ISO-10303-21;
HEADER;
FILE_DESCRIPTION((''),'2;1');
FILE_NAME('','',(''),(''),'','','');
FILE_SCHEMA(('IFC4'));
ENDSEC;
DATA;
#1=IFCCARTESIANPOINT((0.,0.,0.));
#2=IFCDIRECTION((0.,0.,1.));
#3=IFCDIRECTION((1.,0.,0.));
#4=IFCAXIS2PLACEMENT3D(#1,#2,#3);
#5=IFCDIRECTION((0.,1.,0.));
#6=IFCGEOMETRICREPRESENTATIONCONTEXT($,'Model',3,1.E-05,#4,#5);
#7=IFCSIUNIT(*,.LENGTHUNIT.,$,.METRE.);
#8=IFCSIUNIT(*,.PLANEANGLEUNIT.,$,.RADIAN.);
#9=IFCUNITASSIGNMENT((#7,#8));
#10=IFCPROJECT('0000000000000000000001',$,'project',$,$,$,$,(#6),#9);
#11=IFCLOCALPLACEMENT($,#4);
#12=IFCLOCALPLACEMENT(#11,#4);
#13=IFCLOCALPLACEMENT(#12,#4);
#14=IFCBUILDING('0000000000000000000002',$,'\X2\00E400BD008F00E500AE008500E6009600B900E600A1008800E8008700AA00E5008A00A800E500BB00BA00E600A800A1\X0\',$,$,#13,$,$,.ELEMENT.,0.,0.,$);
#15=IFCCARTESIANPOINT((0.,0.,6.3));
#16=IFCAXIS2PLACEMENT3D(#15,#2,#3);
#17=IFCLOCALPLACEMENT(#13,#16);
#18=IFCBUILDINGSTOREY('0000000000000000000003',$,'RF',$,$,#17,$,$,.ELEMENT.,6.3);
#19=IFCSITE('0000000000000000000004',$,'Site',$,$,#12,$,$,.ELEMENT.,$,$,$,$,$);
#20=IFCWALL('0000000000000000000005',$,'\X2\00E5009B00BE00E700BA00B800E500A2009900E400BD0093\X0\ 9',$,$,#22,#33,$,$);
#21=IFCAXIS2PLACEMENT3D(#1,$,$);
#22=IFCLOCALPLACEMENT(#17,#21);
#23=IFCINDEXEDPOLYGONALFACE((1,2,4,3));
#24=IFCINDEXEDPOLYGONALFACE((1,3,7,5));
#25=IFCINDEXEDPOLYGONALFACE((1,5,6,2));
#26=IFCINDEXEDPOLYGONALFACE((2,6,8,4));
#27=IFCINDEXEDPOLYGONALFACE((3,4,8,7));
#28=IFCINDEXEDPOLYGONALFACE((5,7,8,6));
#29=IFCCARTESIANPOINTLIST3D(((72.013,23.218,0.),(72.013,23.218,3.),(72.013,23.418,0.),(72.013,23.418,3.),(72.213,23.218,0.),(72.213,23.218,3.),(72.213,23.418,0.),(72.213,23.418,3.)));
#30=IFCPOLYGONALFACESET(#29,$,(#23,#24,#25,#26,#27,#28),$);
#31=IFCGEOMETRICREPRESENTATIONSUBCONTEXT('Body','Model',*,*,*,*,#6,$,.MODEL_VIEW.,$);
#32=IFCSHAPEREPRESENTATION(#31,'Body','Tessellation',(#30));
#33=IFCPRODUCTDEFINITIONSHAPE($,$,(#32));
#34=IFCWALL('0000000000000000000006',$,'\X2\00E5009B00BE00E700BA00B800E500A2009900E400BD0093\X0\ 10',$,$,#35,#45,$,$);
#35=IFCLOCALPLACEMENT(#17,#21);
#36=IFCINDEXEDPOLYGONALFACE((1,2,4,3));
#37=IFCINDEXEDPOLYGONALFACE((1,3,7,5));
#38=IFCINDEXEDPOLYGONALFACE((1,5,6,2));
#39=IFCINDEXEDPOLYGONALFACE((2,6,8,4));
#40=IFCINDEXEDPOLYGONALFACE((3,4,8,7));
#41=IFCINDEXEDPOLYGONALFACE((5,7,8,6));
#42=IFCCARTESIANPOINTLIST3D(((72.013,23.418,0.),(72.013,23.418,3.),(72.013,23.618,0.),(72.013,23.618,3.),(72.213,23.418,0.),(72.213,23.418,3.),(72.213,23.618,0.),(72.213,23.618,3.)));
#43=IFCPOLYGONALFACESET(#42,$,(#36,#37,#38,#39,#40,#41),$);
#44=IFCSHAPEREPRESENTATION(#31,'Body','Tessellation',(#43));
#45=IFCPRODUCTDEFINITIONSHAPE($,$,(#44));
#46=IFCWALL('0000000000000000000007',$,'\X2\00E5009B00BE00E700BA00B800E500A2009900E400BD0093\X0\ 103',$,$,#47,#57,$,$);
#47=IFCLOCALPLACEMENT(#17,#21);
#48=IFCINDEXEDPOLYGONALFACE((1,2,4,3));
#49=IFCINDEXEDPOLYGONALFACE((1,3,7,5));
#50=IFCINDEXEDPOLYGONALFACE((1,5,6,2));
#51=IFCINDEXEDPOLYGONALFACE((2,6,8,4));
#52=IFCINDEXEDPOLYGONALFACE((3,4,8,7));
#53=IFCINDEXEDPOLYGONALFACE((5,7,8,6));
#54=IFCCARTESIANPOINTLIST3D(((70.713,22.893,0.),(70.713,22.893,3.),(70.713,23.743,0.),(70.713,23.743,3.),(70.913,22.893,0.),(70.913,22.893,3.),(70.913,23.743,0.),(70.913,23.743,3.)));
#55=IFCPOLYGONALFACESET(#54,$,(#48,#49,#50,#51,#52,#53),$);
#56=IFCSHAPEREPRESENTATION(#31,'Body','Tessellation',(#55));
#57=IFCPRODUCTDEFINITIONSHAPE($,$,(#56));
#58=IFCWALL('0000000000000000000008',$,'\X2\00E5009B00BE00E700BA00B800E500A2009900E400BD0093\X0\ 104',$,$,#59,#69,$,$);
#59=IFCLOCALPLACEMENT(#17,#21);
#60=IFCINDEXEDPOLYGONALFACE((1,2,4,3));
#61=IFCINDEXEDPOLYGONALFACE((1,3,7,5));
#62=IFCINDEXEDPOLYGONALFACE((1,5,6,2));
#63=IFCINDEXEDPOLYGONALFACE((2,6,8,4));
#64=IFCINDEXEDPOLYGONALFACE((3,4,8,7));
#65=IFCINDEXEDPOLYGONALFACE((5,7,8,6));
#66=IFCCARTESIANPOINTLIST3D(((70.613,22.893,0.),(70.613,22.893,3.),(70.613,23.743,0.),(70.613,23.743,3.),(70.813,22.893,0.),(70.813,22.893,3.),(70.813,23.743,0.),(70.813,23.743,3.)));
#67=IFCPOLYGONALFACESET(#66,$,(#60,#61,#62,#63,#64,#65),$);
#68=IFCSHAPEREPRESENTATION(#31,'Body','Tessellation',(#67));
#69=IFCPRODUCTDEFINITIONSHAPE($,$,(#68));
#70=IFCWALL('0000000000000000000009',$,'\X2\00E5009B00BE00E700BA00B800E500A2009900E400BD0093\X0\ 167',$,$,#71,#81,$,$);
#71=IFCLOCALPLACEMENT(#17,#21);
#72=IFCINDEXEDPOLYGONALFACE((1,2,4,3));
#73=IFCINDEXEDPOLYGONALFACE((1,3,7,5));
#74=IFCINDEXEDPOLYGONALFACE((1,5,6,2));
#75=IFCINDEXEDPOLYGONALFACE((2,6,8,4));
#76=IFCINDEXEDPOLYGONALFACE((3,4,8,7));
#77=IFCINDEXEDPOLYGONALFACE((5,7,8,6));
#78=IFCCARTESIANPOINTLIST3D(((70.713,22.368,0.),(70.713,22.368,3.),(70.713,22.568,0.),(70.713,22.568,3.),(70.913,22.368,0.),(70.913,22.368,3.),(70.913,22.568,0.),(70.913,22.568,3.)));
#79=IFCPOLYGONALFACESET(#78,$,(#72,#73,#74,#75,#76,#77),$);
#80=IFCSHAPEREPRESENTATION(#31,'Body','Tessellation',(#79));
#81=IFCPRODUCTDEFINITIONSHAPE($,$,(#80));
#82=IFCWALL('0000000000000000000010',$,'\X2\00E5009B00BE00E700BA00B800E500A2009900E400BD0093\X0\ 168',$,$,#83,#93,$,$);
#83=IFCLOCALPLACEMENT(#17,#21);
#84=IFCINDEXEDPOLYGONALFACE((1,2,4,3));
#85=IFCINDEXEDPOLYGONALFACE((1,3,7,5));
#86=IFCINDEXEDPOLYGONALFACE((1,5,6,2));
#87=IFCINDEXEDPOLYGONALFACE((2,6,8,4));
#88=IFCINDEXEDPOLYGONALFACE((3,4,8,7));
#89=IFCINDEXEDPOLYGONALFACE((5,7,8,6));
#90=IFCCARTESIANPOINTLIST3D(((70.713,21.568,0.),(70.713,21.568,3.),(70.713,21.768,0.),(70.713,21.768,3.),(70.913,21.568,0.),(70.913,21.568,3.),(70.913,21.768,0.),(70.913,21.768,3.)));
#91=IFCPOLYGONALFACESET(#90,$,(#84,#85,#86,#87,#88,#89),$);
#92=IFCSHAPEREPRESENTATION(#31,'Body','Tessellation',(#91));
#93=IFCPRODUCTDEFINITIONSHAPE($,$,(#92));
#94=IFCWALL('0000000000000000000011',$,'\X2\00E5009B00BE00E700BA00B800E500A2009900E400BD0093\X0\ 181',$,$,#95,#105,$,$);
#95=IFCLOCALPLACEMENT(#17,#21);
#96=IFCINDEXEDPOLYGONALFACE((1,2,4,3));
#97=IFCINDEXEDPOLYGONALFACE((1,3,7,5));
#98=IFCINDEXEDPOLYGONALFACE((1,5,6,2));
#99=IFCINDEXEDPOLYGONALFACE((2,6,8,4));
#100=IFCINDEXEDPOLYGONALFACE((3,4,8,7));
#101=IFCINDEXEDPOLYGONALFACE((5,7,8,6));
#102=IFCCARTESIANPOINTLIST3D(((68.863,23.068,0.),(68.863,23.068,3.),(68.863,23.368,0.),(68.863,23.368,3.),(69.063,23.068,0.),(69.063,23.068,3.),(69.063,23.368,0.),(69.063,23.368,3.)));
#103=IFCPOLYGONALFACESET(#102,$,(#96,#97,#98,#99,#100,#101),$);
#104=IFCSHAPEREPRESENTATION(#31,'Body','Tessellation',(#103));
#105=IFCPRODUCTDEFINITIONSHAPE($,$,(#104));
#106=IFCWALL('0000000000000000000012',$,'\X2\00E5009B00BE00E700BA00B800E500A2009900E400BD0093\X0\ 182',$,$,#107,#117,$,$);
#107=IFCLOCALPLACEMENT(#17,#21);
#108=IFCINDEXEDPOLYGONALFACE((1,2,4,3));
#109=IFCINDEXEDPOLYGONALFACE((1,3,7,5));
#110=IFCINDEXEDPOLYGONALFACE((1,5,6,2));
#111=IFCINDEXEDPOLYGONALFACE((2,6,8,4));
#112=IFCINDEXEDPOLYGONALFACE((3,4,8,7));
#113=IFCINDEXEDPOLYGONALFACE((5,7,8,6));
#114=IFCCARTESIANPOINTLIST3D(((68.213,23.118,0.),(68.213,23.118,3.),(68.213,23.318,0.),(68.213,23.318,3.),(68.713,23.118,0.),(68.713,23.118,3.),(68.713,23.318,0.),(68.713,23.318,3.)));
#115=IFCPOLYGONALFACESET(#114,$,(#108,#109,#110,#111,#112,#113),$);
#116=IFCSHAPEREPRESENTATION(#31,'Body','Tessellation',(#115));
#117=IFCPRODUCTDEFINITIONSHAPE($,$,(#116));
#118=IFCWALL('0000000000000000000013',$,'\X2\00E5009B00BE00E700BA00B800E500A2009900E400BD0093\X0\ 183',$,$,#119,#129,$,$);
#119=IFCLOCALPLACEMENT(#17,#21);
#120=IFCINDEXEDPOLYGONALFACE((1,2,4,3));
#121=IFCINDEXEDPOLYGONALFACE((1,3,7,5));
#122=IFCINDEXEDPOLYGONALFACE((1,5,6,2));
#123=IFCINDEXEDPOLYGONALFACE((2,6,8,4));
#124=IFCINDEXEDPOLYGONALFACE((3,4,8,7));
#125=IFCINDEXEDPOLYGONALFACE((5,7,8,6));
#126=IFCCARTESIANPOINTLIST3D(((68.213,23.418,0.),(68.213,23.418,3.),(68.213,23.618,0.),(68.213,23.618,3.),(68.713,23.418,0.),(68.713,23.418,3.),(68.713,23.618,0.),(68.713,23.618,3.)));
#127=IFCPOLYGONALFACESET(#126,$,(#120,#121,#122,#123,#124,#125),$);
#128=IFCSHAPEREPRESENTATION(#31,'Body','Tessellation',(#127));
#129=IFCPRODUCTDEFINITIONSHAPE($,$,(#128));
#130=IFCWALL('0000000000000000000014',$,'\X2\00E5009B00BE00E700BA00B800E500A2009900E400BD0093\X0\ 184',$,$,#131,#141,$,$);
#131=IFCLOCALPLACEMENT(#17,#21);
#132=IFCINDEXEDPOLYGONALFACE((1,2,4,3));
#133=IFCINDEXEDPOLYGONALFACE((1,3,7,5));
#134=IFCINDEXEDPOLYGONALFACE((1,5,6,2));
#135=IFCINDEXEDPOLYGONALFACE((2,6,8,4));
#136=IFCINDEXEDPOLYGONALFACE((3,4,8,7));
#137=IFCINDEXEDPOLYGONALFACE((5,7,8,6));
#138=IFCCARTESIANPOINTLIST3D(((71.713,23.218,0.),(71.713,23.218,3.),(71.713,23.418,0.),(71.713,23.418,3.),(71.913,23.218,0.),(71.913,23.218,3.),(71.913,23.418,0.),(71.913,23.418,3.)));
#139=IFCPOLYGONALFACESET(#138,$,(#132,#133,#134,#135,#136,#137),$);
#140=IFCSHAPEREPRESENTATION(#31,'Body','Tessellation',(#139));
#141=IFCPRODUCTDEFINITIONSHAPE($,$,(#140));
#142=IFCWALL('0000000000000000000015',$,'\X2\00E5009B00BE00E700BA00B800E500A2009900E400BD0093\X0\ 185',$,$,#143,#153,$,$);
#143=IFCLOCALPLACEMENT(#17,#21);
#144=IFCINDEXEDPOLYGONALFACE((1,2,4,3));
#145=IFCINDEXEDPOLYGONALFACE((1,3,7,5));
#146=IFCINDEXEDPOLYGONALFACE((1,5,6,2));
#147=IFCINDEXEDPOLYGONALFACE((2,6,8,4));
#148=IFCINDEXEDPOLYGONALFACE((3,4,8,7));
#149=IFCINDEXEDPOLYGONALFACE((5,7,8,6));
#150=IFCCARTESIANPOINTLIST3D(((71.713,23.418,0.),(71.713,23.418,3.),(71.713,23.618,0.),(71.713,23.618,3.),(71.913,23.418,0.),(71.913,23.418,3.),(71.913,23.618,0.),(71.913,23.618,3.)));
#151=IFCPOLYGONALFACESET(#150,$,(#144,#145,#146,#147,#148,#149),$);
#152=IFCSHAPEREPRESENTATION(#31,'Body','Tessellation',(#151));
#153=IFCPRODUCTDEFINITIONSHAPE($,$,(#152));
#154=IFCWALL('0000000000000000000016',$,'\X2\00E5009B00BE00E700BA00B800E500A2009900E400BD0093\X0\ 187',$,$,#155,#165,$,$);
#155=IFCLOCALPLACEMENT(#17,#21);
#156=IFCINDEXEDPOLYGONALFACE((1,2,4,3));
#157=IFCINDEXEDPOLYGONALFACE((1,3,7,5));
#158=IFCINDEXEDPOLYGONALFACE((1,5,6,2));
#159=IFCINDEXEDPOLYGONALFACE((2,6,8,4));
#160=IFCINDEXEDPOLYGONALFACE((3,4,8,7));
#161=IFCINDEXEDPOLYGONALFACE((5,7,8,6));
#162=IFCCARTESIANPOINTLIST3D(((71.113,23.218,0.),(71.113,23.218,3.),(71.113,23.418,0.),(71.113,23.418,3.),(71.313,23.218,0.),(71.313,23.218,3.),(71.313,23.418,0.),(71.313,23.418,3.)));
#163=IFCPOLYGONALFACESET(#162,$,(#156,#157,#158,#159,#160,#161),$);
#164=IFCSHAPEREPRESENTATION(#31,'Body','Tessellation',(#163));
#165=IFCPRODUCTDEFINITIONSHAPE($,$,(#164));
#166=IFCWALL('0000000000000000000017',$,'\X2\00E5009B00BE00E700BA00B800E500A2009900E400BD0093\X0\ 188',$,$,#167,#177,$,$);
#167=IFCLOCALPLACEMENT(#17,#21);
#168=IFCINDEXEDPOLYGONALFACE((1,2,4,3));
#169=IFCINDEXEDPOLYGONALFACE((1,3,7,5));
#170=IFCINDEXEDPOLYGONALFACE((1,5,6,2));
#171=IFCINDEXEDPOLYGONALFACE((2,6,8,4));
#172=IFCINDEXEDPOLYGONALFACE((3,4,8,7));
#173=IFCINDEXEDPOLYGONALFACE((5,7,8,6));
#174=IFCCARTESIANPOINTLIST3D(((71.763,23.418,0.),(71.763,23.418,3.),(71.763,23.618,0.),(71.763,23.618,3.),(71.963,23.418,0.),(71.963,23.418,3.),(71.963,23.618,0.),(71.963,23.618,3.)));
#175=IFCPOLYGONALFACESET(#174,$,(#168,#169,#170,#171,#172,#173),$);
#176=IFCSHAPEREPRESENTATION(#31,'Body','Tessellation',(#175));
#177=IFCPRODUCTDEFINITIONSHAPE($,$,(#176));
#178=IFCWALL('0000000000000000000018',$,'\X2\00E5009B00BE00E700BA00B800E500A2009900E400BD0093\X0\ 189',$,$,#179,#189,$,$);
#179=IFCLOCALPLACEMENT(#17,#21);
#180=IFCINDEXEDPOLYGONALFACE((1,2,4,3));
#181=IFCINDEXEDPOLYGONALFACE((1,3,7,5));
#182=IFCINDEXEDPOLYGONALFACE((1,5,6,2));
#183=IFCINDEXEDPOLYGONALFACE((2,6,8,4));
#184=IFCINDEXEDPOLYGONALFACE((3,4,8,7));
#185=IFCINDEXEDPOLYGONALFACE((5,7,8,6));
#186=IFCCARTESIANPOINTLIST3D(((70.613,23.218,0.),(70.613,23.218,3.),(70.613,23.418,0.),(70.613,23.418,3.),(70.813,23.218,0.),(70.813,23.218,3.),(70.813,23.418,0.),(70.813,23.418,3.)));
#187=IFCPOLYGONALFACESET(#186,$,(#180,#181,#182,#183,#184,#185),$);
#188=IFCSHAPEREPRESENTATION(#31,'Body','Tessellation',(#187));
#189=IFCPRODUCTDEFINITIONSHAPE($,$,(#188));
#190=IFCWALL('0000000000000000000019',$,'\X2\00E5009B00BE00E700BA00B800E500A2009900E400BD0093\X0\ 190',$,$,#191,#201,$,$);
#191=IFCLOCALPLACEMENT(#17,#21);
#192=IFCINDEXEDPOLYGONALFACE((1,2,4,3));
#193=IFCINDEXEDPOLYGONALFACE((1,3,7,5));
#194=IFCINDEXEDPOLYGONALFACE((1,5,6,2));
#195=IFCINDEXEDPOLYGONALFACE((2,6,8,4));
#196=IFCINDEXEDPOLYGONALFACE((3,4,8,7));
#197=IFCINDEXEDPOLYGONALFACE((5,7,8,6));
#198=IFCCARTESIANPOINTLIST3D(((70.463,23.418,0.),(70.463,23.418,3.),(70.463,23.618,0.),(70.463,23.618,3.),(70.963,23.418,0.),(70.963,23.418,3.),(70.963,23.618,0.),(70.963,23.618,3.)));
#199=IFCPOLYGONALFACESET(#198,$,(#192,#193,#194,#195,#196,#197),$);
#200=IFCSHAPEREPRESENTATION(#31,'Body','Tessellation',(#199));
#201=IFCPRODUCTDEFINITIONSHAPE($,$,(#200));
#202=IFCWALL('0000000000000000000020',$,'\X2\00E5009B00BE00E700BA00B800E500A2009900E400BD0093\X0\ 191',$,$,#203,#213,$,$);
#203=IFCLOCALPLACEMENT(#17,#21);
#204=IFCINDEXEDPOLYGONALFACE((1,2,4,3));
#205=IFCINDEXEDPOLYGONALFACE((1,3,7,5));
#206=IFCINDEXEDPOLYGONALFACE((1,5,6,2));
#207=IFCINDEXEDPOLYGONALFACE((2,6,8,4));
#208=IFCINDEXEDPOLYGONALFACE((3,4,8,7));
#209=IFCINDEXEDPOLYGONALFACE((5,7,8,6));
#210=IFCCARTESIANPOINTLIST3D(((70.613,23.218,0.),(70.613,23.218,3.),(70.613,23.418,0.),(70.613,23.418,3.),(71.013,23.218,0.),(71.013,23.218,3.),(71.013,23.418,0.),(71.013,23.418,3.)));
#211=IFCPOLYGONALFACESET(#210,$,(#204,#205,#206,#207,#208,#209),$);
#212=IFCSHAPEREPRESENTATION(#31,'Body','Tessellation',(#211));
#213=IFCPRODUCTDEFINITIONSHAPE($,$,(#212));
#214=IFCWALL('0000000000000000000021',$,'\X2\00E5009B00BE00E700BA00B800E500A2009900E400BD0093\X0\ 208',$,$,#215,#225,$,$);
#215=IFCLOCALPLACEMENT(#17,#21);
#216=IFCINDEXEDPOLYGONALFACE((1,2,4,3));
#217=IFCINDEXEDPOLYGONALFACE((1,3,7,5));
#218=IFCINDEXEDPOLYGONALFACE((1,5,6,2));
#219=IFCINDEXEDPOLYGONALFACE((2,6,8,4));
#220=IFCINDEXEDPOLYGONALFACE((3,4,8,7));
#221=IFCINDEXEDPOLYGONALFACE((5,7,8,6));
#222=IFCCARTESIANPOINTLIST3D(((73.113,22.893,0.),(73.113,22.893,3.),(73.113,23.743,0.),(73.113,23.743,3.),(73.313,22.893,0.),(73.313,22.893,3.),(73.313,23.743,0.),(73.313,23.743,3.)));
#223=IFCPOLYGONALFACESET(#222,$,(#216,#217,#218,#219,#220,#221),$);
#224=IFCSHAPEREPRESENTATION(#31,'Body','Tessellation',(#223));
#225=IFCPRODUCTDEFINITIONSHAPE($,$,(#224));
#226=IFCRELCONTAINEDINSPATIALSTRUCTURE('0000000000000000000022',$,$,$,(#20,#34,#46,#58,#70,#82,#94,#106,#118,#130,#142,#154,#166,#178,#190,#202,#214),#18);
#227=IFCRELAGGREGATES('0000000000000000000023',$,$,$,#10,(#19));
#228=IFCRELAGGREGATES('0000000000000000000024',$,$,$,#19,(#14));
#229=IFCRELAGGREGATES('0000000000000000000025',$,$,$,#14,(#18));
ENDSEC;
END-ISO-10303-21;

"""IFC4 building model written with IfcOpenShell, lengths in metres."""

from ifc_helpers import new_model, si_unit, direction, frame, frame_2d, origin_with_axes, place, context, subcontext, project, spatial, rectangle, extrude, element, save


model = new_model("IFC4")

# Units and contexts
model_context = context("Model", 3, precision=1e-05, world=origin_with_axes(), true_north=direction((0.0, 1.0, 0.0)))
body_context = subcontext(model_context, "Body", "Model", "MODEL_VIEW")
ifc_project = project(units=[si_unit("LENGTHUNIT", "METRE"), si_unit("PLANEANGLEUNIT", "RADIAN")], contexts=[model_context])

# Site, building, storey
placement = place(None, origin_with_axes())
site_placement = place(placement, origin_with_axes())
site = spatial("IfcSite", under=ifc_project, at=site_placement, Name="Site", CompositionType="ELEMENT")
building_placement = place(site_placement, origin_with_axes())
building = spatial("IfcBuilding", under=site, at=building_placement, Name="ä½\u008få®\u0085æ\u0096¹æ¡\u0088è\u0087ªå\u008a¨å»ºæ¨¡", CompositionType="ELEMENT", ElevationOfRefHeight=0.0, ElevationOfTerrain=0.0)
storey_placement = place(building_placement, frame((0.0, 0.0, 6.3), z_axis=(0.0, 0.0, 1.0), x_axis=(1.0, 0.0, 0.0)))
storey = spatial("IfcBuildingStorey", under=building, at=storey_placement, Name="RF", CompositionType="ELEMENT", Elevation=6.3)

# Walls
for number, where, z_axis, x_axis, name in (
    (1, (72.113, 23.318, 0.0), (0.0, 0.0, 1.0), (-1.0, 0.0, 0.0), "å\u009b¾çº¸å¢\u0099ä½\u0093 9"),
    (2, (72.113, 23.518, 0.0), (0.0, 0.0, 1.0), (-1.0, 0.0, 0.0), "å\u009b¾çº¸å¢\u0099ä½\u0093 10"),
):
    element("IfcWall", number, at=place(storey_placement, frame(where, z_axis=z_axis, x_axis=x_axis)), inside=storey, Name=name, context=body_context, shape_type="SweptSolid", body=[
        extrude(rectangle(XDim=0.2, YDim=0.2, at=frame_2d((0.0, 0.0), x_axis=(1.0, 0.0, 0.0))), frame((0.0, 0.0, 0.0), z_axis=(0.0, 0.0, 1.0)), (0.0, 0.0, 1.0), 3.0),
    ])
for number, where, z_axis, x_axis, name in (
    (3, (70.813, 23.318, 0.0), (0.0, 0.0, 1.0), (0.0, -1.0, 0.0), "å\u009b¾çº¸å¢\u0099ä½\u0093 103"),
    (4, (70.713, 23.318, 0.0), (0.0, 0.0, 1.0), (0.0, -1.0, 0.0), "å\u009b¾çº¸å¢\u0099ä½\u0093 104"),
):
    element("IfcWall", number, at=place(storey_placement, frame(where, z_axis=z_axis, x_axis=x_axis)), inside=storey, Name=name, context=body_context, shape_type="SweptSolid", body=[
        extrude(rectangle(XDim=0.85, YDim=0.2, at=frame_2d((0.0, 0.0), x_axis=(1.0, 0.0, 0.0))), frame((0.0, 0.0, 0.0), z_axis=(0.0, 0.0, 1.0)), (0.0, 0.0, 1.0), 3.0),
    ])
for number, where, z_axis, x_axis, name in (
    (5, (70.813, 22.468, 0.0), (0.0, 0.0, 1.0), (-1.0, 0.0, 0.0), "å\u009b¾çº¸å¢\u0099ä½\u0093 167"),
    (6, (70.813, 21.668, 0.0), (0.0, 0.0, 1.0), (0.0, -1.0, 0.0), "å\u009b¾çº¸å¢\u0099ä½\u0093 168"),
):
    element("IfcWall", number, at=place(storey_placement, frame(where, z_axis=z_axis, x_axis=x_axis)), inside=storey, Name=name, context=body_context, shape_type="SweptSolid", body=[
        extrude(rectangle(XDim=0.2, YDim=0.2, at=frame_2d((0.0, 0.0), x_axis=(1.0, 0.0, 0.0))), frame((0.0, 0.0, 0.0), z_axis=(0.0, 0.0, 1.0)), (0.0, 0.0, 1.0), 3.0),
    ])
wall_1_placement = place(storey_placement, frame((68.963, 23.218, 0.0), z_axis=(0.0, 0.0, 1.0), x_axis=(0.0, 1.0, 0.0)))
element("IfcWall", 7, at=wall_1_placement, inside=storey, Name="å\u009b¾çº¸å¢\u0099ä½\u0093 181", context=body_context, shape_type="SweptSolid", body=[
    extrude(rectangle(XDim=0.3, YDim=0.2, at=frame_2d((0.0, 0.0), x_axis=(1.0, 0.0, 0.0))), frame((0.0, 0.0, 0.0), z_axis=(0.0, 0.0, 1.0)), (0.0, 0.0, 1.0), 3.0),
])
for number, where, z_axis, x_axis, name in (
    (8, (68.463, 23.218, 0.0), (0.0, 0.0, 1.0), (1.0, 0.0, 0.0), "å\u009b¾çº¸å¢\u0099ä½\u0093 182"),
    (9, (68.463, 23.518, 0.0), (0.0, 0.0, 1.0), (1.0, 0.0, 0.0), "å\u009b¾çº¸å¢\u0099ä½\u0093 183"),
):
    element("IfcWall", number, at=place(storey_placement, frame(where, z_axis=z_axis, x_axis=x_axis)), inside=storey, Name=name, context=body_context, shape_type="SweptSolid", body=[
        extrude(rectangle(XDim=0.5, YDim=0.2, at=frame_2d((0.0, 0.0), x_axis=(1.0, 0.0, 0.0))), frame((0.0, 0.0, 0.0), z_axis=(0.0, 0.0, 1.0)), (0.0, 0.0, 1.0), 3.0),
    ])
for number, where, z_axis, x_axis, name in (
    (10, (71.813, 23.318, 0.0), (0.0, 0.0, 1.0), (1.0, 0.0, 0.0), "å\u009b¾çº¸å¢\u0099ä½\u0093 184"),
    (11, (71.813, 23.518, 0.0), (0.0, 0.0, 1.0), (1.0, 0.0, 0.0), "å\u009b¾çº¸å¢\u0099ä½\u0093 185"),
    (12, (71.213, 23.318, 0.0), (0.0, 0.0, 1.0), (0.0, 1.0, 0.0), "å\u009b¾çº¸å¢\u0099ä½\u0093 187"),
    (13, (71.863, 23.518, 0.0), (0.0, 0.0, 1.0), (1.0, 0.0, 0.0), "å\u009b¾çº¸å¢\u0099ä½\u0093 188"),
    (14, (70.713, 23.318, 0.0), (0.0, 0.0, 1.0), (0.0, 1.0, 0.0), "å\u009b¾çº¸å¢\u0099ä½\u0093 189"),
):
    element("IfcWall", number, at=place(storey_placement, frame(where, z_axis=z_axis, x_axis=x_axis)), inside=storey, Name=name, context=body_context, shape_type="SweptSolid", body=[
        extrude(rectangle(XDim=0.2, YDim=0.2, at=frame_2d((0.0, 0.0), x_axis=(1.0, 0.0, 0.0))), frame((0.0, 0.0, 0.0), z_axis=(0.0, 0.0, 1.0)), (0.0, 0.0, 1.0), 3.0),
    ])
wall_2_placement = place(storey_placement, frame((70.713, 23.518, 0.0), z_axis=(0.0, 0.0, 1.0), x_axis=(1.0, 0.0, 0.0)))
element("IfcWall", 15, at=wall_2_placement, inside=storey, Name="å\u009b¾çº¸å¢\u0099ä½\u0093 190", context=body_context, shape_type="SweptSolid", body=[
    extrude(rectangle(XDim=0.5, YDim=0.2, at=frame_2d((0.0, 0.0), x_axis=(1.0, 0.0, 0.0))), frame((0.0, 0.0, 0.0), z_axis=(0.0, 0.0, 1.0)), (0.0, 0.0, 1.0), 3.0),
])
wall_3_placement = place(storey_placement, frame((70.813, 23.318, 0.0), z_axis=(0.0, 0.0, 1.0), x_axis=(1.0, 0.0, 0.0)))
element("IfcWall", 16, at=wall_3_placement, inside=storey, Name="å\u009b¾çº¸å¢\u0099ä½\u0093 191", context=body_context, shape_type="SweptSolid", body=[
    extrude(rectangle(XDim=0.4, YDim=0.2, at=frame_2d((0.0, 0.0), x_axis=(1.0, 0.0, 0.0))), frame((0.0, 0.0, 0.0), z_axis=(0.0, 0.0, 1.0)), (0.0, 0.0, 1.0), 3.0),
])
for number, where, z_axis, x_axis, name in (
    (17, (73.213, 23.318, 0.0), (0.0, 0.0, 1.0), (0.0, -1.0, 0.0), "å\u009b¾çº¸å¢\u0099ä½\u0093 208"),
):
    element("IfcWall", number, at=place(storey_placement, frame(where, z_axis=z_axis, x_axis=x_axis)), inside=storey, Name=name, context=body_context, shape_type="SweptSolid", body=[
        extrude(rectangle(XDim=0.85, YDim=0.2, at=frame_2d((0.0, 0.0), x_axis=(1.0, 0.0, 0.0))), frame((0.0, 0.0, 0.0), z_axis=(0.0, 0.0, 1.0)), (0.0, 0.0, 1.0), 3.0),
    ])

save(model, "model.ifc")
